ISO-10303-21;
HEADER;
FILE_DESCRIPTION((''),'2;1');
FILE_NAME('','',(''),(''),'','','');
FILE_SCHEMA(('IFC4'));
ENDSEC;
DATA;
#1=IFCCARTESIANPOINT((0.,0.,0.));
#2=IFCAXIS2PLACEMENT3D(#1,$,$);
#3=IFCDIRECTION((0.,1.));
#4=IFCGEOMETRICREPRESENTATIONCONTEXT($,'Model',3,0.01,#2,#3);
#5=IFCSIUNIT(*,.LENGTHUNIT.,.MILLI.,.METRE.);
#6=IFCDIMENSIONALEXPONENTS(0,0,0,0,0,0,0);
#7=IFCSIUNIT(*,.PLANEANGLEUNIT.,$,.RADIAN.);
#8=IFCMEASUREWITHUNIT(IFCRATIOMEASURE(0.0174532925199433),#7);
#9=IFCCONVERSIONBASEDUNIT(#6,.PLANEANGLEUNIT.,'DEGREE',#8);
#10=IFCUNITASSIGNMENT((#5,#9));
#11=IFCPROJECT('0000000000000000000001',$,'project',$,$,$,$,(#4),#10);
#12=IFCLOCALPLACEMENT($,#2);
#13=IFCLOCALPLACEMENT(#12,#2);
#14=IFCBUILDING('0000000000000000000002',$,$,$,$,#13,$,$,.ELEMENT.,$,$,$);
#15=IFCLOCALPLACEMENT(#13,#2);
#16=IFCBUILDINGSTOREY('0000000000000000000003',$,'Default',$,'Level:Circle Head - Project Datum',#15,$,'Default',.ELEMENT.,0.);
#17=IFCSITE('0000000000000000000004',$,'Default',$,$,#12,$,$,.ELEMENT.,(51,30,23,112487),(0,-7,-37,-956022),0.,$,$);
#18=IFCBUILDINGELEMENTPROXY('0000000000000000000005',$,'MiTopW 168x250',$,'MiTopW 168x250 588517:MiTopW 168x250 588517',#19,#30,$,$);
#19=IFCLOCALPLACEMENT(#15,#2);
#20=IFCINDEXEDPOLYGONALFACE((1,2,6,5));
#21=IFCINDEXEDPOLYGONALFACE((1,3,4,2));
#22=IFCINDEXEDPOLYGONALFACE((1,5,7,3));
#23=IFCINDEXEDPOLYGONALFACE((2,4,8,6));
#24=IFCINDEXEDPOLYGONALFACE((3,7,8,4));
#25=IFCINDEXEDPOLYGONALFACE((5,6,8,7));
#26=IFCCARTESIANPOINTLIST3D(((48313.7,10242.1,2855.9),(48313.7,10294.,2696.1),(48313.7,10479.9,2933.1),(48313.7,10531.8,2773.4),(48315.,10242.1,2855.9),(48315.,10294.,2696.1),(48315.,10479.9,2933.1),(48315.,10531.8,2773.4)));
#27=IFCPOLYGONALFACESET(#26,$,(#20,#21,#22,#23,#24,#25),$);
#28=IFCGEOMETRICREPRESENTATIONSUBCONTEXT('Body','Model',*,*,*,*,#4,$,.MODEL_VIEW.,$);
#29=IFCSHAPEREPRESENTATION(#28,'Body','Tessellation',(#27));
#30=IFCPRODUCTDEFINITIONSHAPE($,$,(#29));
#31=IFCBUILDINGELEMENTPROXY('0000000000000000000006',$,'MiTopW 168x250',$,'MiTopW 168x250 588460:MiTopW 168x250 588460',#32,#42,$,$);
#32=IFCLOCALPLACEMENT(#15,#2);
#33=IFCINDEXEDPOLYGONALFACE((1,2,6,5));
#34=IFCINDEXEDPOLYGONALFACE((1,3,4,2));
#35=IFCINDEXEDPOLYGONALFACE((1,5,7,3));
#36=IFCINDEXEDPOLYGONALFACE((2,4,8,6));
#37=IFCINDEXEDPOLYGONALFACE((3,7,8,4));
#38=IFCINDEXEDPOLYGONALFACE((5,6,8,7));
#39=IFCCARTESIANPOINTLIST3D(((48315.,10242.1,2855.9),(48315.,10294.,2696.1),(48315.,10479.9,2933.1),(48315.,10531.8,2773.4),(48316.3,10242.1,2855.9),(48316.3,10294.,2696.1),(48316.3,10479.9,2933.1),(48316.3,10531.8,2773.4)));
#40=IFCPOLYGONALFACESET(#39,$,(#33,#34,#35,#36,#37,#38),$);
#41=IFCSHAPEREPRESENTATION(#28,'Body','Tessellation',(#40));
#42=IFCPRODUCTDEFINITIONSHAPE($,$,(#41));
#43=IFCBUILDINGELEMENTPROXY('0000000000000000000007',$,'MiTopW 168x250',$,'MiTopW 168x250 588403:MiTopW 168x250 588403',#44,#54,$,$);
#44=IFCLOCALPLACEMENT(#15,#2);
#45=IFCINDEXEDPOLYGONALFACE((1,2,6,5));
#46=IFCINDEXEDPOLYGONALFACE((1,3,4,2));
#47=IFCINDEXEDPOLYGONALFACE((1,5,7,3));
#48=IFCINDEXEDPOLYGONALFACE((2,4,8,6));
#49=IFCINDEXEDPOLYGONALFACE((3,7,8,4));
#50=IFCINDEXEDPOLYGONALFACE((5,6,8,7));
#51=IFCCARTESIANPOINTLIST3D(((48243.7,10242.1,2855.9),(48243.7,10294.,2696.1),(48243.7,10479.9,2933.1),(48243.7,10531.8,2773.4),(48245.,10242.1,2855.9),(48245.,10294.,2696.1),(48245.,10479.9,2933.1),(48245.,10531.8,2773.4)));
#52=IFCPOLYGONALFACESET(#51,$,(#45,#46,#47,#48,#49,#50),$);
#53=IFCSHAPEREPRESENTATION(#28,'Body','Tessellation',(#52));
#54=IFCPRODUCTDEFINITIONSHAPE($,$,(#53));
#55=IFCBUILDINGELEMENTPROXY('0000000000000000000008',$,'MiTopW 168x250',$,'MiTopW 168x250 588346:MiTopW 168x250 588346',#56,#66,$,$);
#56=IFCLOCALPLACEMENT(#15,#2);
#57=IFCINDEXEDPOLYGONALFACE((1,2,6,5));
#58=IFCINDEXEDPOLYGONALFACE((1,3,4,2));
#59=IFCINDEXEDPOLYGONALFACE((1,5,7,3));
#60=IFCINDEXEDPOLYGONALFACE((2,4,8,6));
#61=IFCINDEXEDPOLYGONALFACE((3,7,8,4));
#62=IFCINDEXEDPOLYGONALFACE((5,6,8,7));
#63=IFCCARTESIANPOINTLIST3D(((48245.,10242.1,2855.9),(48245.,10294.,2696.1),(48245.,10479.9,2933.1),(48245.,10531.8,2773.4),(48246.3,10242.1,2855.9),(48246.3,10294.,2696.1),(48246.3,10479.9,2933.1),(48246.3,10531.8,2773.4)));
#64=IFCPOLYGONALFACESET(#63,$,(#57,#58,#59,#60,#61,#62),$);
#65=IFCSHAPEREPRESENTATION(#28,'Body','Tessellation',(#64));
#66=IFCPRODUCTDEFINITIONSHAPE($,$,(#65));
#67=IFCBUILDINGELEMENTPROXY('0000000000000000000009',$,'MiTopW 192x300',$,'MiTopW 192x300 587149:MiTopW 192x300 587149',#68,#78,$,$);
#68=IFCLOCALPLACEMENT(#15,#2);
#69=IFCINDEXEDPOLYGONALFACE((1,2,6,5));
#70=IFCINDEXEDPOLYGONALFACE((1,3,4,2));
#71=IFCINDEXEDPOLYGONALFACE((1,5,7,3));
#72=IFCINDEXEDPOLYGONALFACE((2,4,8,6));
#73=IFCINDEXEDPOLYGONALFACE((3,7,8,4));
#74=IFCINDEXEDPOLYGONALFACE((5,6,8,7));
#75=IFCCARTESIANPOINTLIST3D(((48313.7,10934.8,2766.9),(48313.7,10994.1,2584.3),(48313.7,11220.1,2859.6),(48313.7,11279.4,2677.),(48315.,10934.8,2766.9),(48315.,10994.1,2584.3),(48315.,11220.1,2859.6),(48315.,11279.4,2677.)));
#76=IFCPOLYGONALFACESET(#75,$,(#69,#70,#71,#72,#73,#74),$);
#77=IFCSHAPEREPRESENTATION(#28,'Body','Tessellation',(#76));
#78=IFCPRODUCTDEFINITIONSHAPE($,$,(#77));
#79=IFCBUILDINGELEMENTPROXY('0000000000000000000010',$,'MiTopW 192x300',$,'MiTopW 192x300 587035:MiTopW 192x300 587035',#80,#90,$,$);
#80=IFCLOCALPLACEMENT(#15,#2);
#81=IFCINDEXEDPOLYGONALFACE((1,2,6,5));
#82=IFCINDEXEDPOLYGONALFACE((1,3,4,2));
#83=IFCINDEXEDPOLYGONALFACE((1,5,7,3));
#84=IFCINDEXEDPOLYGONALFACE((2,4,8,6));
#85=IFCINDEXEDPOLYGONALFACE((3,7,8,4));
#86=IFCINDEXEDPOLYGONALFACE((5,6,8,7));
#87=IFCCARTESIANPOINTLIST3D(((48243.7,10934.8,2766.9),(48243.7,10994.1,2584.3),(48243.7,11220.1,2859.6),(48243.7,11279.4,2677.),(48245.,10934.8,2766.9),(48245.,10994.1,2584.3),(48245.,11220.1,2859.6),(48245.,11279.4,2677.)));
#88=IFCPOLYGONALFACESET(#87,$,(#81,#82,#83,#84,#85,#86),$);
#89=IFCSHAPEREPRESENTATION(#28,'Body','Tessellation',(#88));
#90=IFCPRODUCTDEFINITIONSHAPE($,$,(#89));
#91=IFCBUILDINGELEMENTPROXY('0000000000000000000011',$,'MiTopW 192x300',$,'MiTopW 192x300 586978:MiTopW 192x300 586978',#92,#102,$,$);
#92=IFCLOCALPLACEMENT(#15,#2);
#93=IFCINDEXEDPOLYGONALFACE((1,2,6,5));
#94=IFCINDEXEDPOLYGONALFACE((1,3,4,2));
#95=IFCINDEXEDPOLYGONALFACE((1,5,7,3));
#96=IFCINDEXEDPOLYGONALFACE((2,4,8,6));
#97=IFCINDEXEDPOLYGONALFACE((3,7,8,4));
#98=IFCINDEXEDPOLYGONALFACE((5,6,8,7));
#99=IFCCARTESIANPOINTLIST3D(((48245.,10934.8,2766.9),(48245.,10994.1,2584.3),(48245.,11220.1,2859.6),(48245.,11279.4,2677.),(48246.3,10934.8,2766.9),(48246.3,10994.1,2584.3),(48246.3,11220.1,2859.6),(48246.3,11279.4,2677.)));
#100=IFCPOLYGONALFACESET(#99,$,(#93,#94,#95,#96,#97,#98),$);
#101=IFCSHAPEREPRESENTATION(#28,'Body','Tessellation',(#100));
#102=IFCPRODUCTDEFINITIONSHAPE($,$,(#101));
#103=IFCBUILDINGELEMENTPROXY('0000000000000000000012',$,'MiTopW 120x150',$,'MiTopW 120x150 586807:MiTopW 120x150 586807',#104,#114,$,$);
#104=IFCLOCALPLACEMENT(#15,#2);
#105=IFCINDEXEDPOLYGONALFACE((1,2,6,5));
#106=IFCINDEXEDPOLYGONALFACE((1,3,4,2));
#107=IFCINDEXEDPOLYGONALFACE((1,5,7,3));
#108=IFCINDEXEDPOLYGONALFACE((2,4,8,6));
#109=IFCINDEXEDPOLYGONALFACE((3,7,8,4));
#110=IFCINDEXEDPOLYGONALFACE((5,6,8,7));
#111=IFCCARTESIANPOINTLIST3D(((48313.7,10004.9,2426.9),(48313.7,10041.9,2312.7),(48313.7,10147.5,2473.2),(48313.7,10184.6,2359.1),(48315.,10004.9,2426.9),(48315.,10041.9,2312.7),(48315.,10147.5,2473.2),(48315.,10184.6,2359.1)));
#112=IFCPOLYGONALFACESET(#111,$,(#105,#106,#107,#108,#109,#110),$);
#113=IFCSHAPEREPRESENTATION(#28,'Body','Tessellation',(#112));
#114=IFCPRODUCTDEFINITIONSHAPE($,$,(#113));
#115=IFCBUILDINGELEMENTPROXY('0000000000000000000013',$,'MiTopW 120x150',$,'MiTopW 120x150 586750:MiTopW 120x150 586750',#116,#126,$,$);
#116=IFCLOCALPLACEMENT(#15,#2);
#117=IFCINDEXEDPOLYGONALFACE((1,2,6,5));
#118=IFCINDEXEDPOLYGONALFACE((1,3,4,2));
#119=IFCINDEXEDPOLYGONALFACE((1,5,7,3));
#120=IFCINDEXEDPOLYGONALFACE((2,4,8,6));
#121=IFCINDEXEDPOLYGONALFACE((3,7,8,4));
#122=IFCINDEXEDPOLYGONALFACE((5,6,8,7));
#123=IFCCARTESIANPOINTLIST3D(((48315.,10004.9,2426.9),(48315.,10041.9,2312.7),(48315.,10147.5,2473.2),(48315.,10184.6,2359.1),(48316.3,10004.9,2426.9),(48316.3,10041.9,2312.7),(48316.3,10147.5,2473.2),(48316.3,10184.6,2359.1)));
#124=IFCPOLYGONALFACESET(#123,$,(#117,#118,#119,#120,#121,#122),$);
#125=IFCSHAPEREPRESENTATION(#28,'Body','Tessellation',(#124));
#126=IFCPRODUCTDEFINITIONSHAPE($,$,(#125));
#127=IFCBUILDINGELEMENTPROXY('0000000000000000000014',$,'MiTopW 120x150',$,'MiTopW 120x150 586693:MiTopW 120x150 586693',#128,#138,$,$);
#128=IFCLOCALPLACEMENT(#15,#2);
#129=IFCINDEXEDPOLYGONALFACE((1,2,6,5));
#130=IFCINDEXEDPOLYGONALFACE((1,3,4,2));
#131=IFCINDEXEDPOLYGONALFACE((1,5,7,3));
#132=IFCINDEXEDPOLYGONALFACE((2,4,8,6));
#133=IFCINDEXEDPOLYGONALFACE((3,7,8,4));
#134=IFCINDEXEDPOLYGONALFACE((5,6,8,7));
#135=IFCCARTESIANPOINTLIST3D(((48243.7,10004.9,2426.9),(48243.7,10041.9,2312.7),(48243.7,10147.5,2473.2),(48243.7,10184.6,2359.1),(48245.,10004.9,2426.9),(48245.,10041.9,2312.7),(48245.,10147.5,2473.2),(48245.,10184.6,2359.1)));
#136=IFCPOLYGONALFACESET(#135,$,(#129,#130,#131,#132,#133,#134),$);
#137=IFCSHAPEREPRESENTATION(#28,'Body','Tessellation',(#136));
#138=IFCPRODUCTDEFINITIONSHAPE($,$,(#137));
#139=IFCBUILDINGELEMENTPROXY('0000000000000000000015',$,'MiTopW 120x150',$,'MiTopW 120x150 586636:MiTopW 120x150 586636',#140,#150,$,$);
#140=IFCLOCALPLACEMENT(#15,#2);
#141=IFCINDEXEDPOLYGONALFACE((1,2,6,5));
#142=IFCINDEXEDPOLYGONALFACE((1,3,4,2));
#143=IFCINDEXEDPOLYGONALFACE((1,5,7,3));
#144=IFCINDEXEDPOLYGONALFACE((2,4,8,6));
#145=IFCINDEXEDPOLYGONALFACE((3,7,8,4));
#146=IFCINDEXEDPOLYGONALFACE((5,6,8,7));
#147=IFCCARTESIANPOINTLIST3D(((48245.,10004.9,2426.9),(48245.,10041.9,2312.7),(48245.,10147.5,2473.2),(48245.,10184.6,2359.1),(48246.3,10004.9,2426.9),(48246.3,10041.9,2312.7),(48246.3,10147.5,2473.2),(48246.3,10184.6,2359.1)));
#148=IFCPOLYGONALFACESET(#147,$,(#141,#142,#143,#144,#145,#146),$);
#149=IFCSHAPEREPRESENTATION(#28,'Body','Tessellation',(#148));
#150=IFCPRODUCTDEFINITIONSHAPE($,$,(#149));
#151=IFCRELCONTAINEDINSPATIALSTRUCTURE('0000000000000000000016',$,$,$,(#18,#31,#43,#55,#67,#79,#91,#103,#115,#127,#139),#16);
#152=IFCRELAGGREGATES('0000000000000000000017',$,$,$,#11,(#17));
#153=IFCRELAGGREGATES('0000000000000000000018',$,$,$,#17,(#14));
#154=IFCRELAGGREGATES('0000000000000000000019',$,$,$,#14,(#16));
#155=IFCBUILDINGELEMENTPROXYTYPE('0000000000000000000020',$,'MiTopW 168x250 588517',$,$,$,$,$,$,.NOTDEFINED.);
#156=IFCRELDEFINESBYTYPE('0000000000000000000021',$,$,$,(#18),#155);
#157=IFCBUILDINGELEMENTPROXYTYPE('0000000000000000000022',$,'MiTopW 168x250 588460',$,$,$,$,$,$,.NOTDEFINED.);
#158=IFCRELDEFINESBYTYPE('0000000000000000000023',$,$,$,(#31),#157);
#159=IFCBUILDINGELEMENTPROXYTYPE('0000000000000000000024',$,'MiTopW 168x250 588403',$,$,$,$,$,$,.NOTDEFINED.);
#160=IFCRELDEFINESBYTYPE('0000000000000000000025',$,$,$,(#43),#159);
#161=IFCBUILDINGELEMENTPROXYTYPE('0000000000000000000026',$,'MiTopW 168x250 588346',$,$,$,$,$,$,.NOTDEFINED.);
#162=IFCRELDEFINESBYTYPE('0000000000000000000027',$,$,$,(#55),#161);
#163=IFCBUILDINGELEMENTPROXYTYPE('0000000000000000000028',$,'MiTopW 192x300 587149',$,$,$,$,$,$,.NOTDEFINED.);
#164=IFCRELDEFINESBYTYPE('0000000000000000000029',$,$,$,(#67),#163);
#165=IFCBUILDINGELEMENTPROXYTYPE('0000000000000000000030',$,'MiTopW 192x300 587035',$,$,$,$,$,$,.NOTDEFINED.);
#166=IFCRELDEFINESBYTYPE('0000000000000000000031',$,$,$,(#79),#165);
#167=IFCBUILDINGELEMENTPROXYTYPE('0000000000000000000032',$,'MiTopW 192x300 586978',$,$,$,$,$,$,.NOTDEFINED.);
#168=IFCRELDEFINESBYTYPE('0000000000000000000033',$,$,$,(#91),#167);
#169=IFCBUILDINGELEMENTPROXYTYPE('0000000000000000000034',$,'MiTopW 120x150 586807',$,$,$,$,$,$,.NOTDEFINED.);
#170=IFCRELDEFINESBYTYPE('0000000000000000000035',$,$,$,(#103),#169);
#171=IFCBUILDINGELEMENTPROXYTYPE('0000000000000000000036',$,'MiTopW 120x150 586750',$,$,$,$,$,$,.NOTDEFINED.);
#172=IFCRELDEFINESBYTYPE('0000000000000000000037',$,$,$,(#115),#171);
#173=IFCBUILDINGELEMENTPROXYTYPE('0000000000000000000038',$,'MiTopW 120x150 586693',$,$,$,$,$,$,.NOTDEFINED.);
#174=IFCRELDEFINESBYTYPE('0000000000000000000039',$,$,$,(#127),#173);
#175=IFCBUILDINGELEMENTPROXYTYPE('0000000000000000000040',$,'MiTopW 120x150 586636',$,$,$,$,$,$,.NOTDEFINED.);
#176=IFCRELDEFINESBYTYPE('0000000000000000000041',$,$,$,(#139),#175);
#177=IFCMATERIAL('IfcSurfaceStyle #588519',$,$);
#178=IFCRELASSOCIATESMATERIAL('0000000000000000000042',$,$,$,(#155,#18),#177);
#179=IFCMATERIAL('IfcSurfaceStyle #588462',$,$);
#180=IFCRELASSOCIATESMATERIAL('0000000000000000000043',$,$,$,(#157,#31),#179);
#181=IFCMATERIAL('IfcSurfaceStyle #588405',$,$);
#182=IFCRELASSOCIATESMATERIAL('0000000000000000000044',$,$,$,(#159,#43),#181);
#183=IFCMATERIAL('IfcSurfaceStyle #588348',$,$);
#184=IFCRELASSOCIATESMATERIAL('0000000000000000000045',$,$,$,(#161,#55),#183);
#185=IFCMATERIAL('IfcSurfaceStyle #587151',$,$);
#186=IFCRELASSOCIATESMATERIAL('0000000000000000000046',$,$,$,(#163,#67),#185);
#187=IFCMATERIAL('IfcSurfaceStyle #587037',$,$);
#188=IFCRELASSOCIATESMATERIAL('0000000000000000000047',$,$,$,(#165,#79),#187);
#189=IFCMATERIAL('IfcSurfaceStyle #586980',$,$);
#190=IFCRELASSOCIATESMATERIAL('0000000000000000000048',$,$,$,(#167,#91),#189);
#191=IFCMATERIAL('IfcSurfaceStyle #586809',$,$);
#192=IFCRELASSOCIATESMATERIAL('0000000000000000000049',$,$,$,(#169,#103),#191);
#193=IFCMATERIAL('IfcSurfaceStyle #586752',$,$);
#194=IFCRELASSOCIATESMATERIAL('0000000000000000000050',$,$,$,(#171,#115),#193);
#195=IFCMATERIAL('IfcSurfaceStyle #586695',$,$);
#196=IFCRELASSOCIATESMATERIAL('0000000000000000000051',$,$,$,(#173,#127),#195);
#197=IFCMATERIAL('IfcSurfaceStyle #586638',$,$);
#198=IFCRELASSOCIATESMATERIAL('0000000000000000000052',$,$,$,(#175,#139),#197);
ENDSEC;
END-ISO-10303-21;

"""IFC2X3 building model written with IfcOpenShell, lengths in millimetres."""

from ifc_helpers import new_model, entity, si_unit, converted_unit, direction, frame, origin, place, context, subcontext, project, spatial, polyline, outline, extrude, source, transform, mapped, material, type_object, type_shapes, element, save


model = new_model("IFC2X3")

# Units and contexts
model_context = context("Model", 3, precision=0.01, world=origin(), true_north=direction((0.0, 1.0)))
body_context = subcontext(model_context, "Body", "Model", "MODEL_VIEW")
ifc_project = project(units=[si_unit("LENGTHUNIT", "METRE", prefix="MILLI"), converted_unit("PLANEANGLEUNIT", "DEGREE", entity("IfcRatioMeasure", 0.0174532925199433), si_unit("PLANEANGLEUNIT", "RADIAN"), dimensions=[0, 0, 0, 0, 0, 0, 0])], contexts=[model_context])

# Site, building, storey
site_placement = place(None, origin())
site = spatial("IfcSite", under=ifc_project, at=site_placement, Name="Default", CompositionType="ELEMENT", RefLatitude=(51, 30, 23, 112487), RefLongitude=(0, -7, -37, -956022), RefElevation=0.0)
building_placement = place(site_placement, origin())
building = spatial("IfcBuilding", under=site, at=building_placement, CompositionType="ELEMENT")
storey_placement = place(building_placement, origin())
storey = spatial("IfcBuildingStorey", under=building, at=storey_placement, Name="Default", ObjectType="Level:Circle Head - Project Datum", LongName="Default", CompositionType="ELEMENT", Elevation=0.0)

# Building element proxies
ifc_material_1 = material(Name="IfcSurfaceStyle #588519")
building_element_proxy_type_1 = type_object("IfcBuildingElementProxyType", Name="MiTopW 168x250 588517", PredefinedType="NOTDEFINED", material=ifc_material_1)
shared_shape_1 = source(origin(), body_context, "Body", "SweptSolid", [
    extrude(outline(polyline([(-125.0, -84.0), (125.0, -84.0), (125.0, 84.0), (-125.0, 84.0), (-125.0, -84.0)])), frame((125.0, 84.0, 0.0), z_axis=(0.0, 0.0, 1.0), x_axis=(-1.0, 0.0, 0.0)), (0.0, 0.0, 1.0), 1.3),
])
type_shapes(building_element_proxy_type_1, [shared_shape_1])
proxy_1_placement = place(building_placement, frame((48315.0, 10242.1, 2855.9), z_axis=(-1.0, 0.0, 0.0), x_axis=(0.0, 0.951057, 0.309017)))
element("IfcBuildingElementProxy", 1, at=proxy_1_placement, inside=storey, type_object=building_element_proxy_type_1, material=ifc_material_1, Name="MiTopW 168x250", ObjectType="MiTopW 168x250 588517:MiTopW 168x250 588517", context=body_context, shape_type="MappedRepresentation", body=[
    mapped(shared_shape_1, transform((0.0, 0.0, 0.0), scale=1.0)),
])
ifc_material_2 = material(Name="IfcSurfaceStyle #588462")
building_element_proxy_type_2 = type_object("IfcBuildingElementProxyType", Name="MiTopW 168x250 588460", PredefinedType="NOTDEFINED", material=ifc_material_2)
shared_shape_2 = source(origin(), body_context, "Body", "SweptSolid", [
    extrude(outline(polyline([(-125.0, -84.0), (125.0, -84.0), (125.0, 84.0), (-125.0, 84.0), (-125.0, -84.0)])), frame((125.0, 84.0, 0.0), z_axis=(0.0, 0.0, 1.0), x_axis=(-1.0, 0.0, 0.0)), (0.0, 0.0, 1.0), 1.3),
])
type_shapes(building_element_proxy_type_2, [shared_shape_2])
proxy_2_placement = place(building_placement, frame((48316.3, 10242.1, 2855.9), z_axis=(-1.0, 0.0, 0.0), x_axis=(0.0, 0.951057, 0.309017)))
element("IfcBuildingElementProxy", 2, at=proxy_2_placement, inside=storey, type_object=building_element_proxy_type_2, material=ifc_material_2, Name="MiTopW 168x250", ObjectType="MiTopW 168x250 588460:MiTopW 168x250 588460", context=body_context, shape_type="MappedRepresentation", body=[
    mapped(shared_shape_2, transform((0.0, 0.0, 0.0), scale=1.0)),
])
ifc_material_3 = material(Name="IfcSurfaceStyle #588405")
building_element_proxy_type_3 = type_object("IfcBuildingElementProxyType", Name="MiTopW 168x250 588403", PredefinedType="NOTDEFINED", material=ifc_material_3)
shared_shape_3 = source(origin(), body_context, "Body", "SweptSolid", [
    extrude(outline(polyline([(-125.0, -84.0), (125.0, -84.0), (125.0, 84.0), (-125.0, 84.0), (-125.0, -84.0)])), frame((125.0, 84.0, 0.0), z_axis=(0.0, 0.0, 1.0), x_axis=(-1.0, 0.0, 0.0)), (0.0, 0.0, 1.0), 1.3),
])
type_shapes(building_element_proxy_type_3, [shared_shape_3])
proxy_3_placement = place(building_placement, frame((48245.0, 10242.1, 2855.9), z_axis=(-1.0, 0.0, 0.0), x_axis=(0.0, 0.951057, 0.309017)))
element("IfcBuildingElementProxy", 3, at=proxy_3_placement, inside=storey, type_object=building_element_proxy_type_3, material=ifc_material_3, Name="MiTopW 168x250", ObjectType="MiTopW 168x250 588403:MiTopW 168x250 588403", context=body_context, shape_type="MappedRepresentation", body=[
    mapped(shared_shape_3, transform((0.0, 0.0, 0.0), scale=1.0)),
])
ifc_material_4 = material(Name="IfcSurfaceStyle #588348")
building_element_proxy_type_4 = type_object("IfcBuildingElementProxyType", Name="MiTopW 168x250 588346", PredefinedType="NOTDEFINED", material=ifc_material_4)
shared_shape_4 = source(origin(), body_context, "Body", "SweptSolid", [
    extrude(outline(polyline([(-125.0, -84.0), (125.0, -84.0), (125.0, 84.0), (-125.0, 84.0), (-125.0, -84.0)])), frame((125.0, 84.0, 0.0), z_axis=(0.0, 0.0, 1.0), x_axis=(-1.0, 0.0, 0.0)), (0.0, 0.0, 1.0), 1.3),
])
type_shapes(building_element_proxy_type_4, [shared_shape_4])
proxy_4_placement = place(building_placement, frame((48246.3, 10242.1, 2855.9), z_axis=(-1.0, 0.0, 0.0), x_axis=(0.0, 0.951057, 0.309017)))
element("IfcBuildingElementProxy", 4, at=proxy_4_placement, inside=storey, type_object=building_element_proxy_type_4, material=ifc_material_4, Name="MiTopW 168x250", ObjectType="MiTopW 168x250 588346:MiTopW 168x250 588346", context=body_context, shape_type="MappedRepresentation", body=[
    mapped(shared_shape_4, transform((0.0, 0.0, 0.0), scale=1.0)),
])
ifc_material_5 = material(Name="IfcSurfaceStyle #587151")
building_element_proxy_type_5 = type_object("IfcBuildingElementProxyType", Name="MiTopW 192x300 587149", PredefinedType="NOTDEFINED", material=ifc_material_5)
shared_shape_5 = source(origin(), body_context, "Body", "SweptSolid", [
    extrude(outline(polyline([(-150.0, -96.0), (150.0, -96.0), (150.0, 96.0), (-150.0, 96.0), (-150.0, -96.0)])), frame((150.0, 96.0, 0.0), z_axis=(0.0, 0.0, 1.0), x_axis=(-1.0, 0.0, 0.0)), (0.0, 0.0, 1.0), 1.3),
])
type_shapes(building_element_proxy_type_5, [shared_shape_5])
proxy_5_placement = place(building_placement, frame((48315.0, 10934.8, 2766.9), z_axis=(-1.0, 0.0, 0.0), x_axis=(0.0, 0.951057, 0.309017)))
element("IfcBuildingElementProxy", 5, at=proxy_5_placement, inside=storey, type_object=building_element_proxy_type_5, material=ifc_material_5, Name="MiTopW 192x300", ObjectType="MiTopW 192x300 587149:MiTopW 192x300 587149", context=body_context, shape_type="MappedRepresentation", body=[
    mapped(shared_shape_5, transform((0.0, 0.0, 0.0), scale=1.0)),
])
ifc_material_6 = material(Name="IfcSurfaceStyle #587037")
building_element_proxy_type_6 = type_object("IfcBuildingElementProxyType", Name="MiTopW 192x300 587035", PredefinedType="NOTDEFINED", material=ifc_material_6)
shared_shape_6 = source(origin(), body_context, "Body", "SweptSolid", [
    extrude(outline(polyline([(-150.0, -96.0), (150.0, -96.0), (150.0, 96.0), (-150.0, 96.0), (-150.0, -96.0)])), frame((150.0, 96.0, 0.0), z_axis=(0.0, 0.0, 1.0), x_axis=(-1.0, 0.0, 0.0)), (0.0, 0.0, 1.0), 1.3),
])
type_shapes(building_element_proxy_type_6, [shared_shape_6])
proxy_6_placement = place(building_placement, frame((48245.0, 10934.8, 2766.9), z_axis=(-1.0, 0.0, 0.0), x_axis=(0.0, 0.951057, 0.309017)))
element("IfcBuildingElementProxy", 6, at=proxy_6_placement, inside=storey, type_object=building_element_proxy_type_6, material=ifc_material_6, Name="MiTopW 192x300", ObjectType="MiTopW 192x300 587035:MiTopW 192x300 587035", context=body_context, shape_type="MappedRepresentation", body=[
    mapped(shared_shape_6, transform((0.0, 0.0, 0.0), scale=1.0)),
])
ifc_material_7 = material(Name="IfcSurfaceStyle #586980")
building_element_proxy_type_7 = type_object("IfcBuildingElementProxyType", Name="MiTopW 192x300 586978", PredefinedType="NOTDEFINED", material=ifc_material_7)
shared_shape_7 = source(origin(), body_context, "Body", "SweptSolid", [
    extrude(outline(polyline([(-150.0, -96.0), (150.0, -96.0), (150.0, 96.0), (-150.0, 96.0), (-150.0, -96.0)])), frame((150.0, 96.0, 0.0), z_axis=(0.0, 0.0, 1.0), x_axis=(-1.0, 0.0, 0.0)), (0.0, 0.0, 1.0), 1.3),
])
type_shapes(building_element_proxy_type_7, [shared_shape_7])
proxy_7_placement = place(building_placement, frame((48246.3, 10934.8, 2766.9), z_axis=(-1.0, 0.0, 0.0), x_axis=(0.0, 0.951057, 0.309017)))
element("IfcBuildingElementProxy", 7, at=proxy_7_placement, inside=storey, type_object=building_element_proxy_type_7, material=ifc_material_7, Name="MiTopW 192x300", ObjectType="MiTopW 192x300 586978:MiTopW 192x300 586978", context=body_context, shape_type="MappedRepresentation", body=[
    mapped(shared_shape_7, transform((0.0, 0.0, 0.0), scale=1.0)),
])
ifc_material_8 = material(Name="IfcSurfaceStyle #586809")
building_element_proxy_type_8 = type_object("IfcBuildingElementProxyType", Name="MiTopW 120x150 586807", PredefinedType="NOTDEFINED", material=ifc_material_8)
shared_shape_8 = source(origin(), body_context, "Body", "SweptSolid", [
    extrude(outline(polyline([(-75.0, -60.0), (75.0, -60.0), (75.0, 60.0), (-75.0, 60.0), (-75.0, -60.0)])), frame((75.0, 60.0, 0.0), z_axis=(0.0, 0.0, 1.0), x_axis=(-1.0, 0.0, 0.0)), (0.0, 0.0, 1.0), 1.3),
])
type_shapes(building_element_proxy_type_8, [shared_shape_8])
proxy_8_placement = place(building_placement, frame((48315.0, 10004.9, 2426.9), z_axis=(-1.0, 0.0, 0.0), x_axis=(0.0, 0.951057, 0.309017)))
element("IfcBuildingElementProxy", 8, at=proxy_8_placement, inside=storey, type_object=building_element_proxy_type_8, material=ifc_material_8, Name="MiTopW 120x150", ObjectType="MiTopW 120x150 586807:MiTopW 120x150 586807", context=body_context, shape_type="MappedRepresentation", body=[
    mapped(shared_shape_8, transform((0.0, 0.0, 0.0), scale=1.0)),
])
ifc_material_9 = material(Name="IfcSurfaceStyle #586752")
building_element_proxy_type_9 = type_object("IfcBuildingElementProxyType", Name="MiTopW 120x150 586750", PredefinedType="NOTDEFINED", material=ifc_material_9)
shared_shape_9 = source(origin(), body_context, "Body", "SweptSolid", [
    extrude(outline(polyline([(-75.0, -60.0), (75.0, -60.0), (75.0, 60.0), (-75.0, 60.0), (-75.0, -60.0)])), frame((75.0, 60.0, 0.0), z_axis=(0.0, 0.0, 1.0), x_axis=(-1.0, 0.0, 0.0)), (0.0, 0.0, 1.0), 1.3),
])
type_shapes(building_element_proxy_type_9, [shared_shape_9])
proxy_9_placement = place(building_placement, frame((48316.3, 10004.9, 2426.9), z_axis=(-1.0, 0.0, 0.0), x_axis=(0.0, 0.951057, 0.309017)))
element("IfcBuildingElementProxy", 9, at=proxy_9_placement, inside=storey, type_object=building_element_proxy_type_9, material=ifc_material_9, Name="MiTopW 120x150", ObjectType="MiTopW 120x150 586750:MiTopW 120x150 586750", context=body_context, shape_type="MappedRepresentation", body=[
    mapped(shared_shape_9, transform((0.0, 0.0, 0.0), scale=1.0)),
])
ifc_material_10 = material(Name="IfcSurfaceStyle #586695")
building_element_proxy_type_10 = type_object("IfcBuildingElementProxyType", Name="MiTopW 120x150 586693", PredefinedType="NOTDEFINED", material=ifc_material_10)
shared_shape_10 = source(origin(), body_context, "Body", "SweptSolid", [
    extrude(outline(polyline([(-75.0, -60.0), (75.0, -60.0), (75.0, 60.0), (-75.0, 60.0), (-75.0, -60.0)])), frame((75.0, 60.0, 0.0), z_axis=(0.0, 0.0, 1.0), x_axis=(-1.0, 0.0, 0.0)), (0.0, 0.0, 1.0), 1.3),
])
type_shapes(building_element_proxy_type_10, [shared_shape_10])
proxy_10_placement = place(building_placement, frame((48245.0, 10004.9, 2426.9), z_axis=(-1.0, 0.0, 0.0), x_axis=(0.0, 0.951057, 0.309017)))
element("IfcBuildingElementProxy", 10, at=proxy_10_placement, inside=storey, type_object=building_element_proxy_type_10, material=ifc_material_10, Name="MiTopW 120x150", ObjectType="MiTopW 120x150 586693:MiTopW 120x150 586693", context=body_context, shape_type="MappedRepresentation", body=[
    mapped(shared_shape_10, transform((0.0, 0.0, 0.0), scale=1.0)),
])
ifc_material_11 = material(Name="IfcSurfaceStyle #586638")
building_element_proxy_type_11 = type_object("IfcBuildingElementProxyType", Name="MiTopW 120x150 586636", PredefinedType="NOTDEFINED", material=ifc_material_11)
shared_shape_11 = source(origin(), body_context, "Body", "SweptSolid", [
    extrude(outline(polyline([(-75.0, -60.0), (75.0, -60.0), (75.0, 60.0), (-75.0, 60.0), (-75.0, -60.0)])), frame((75.0, 60.0, 0.0), z_axis=(0.0, 0.0, 1.0), x_axis=(-1.0, 0.0, 0.0)), (0.0, 0.0, 1.0), 1.3),
])
type_shapes(building_element_proxy_type_11, [shared_shape_11])
proxy_11_placement = place(building_placement, frame((48246.3, 10004.9, 2426.9), z_axis=(-1.0, 0.0, 0.0), x_axis=(0.0, 0.951057, 0.309017)))
element("IfcBuildingElementProxy", 11, at=proxy_11_placement, inside=storey, type_object=building_element_proxy_type_11, material=ifc_material_11, Name="MiTopW 120x150", ObjectType="MiTopW 120x150 586636:MiTopW 120x150 586636", context=body_context, shape_type="MappedRepresentation", body=[
    mapped(shared_shape_11, transform((0.0, 0.0, 0.0), scale=1.0)),
])

save(model, "model.ifc")
